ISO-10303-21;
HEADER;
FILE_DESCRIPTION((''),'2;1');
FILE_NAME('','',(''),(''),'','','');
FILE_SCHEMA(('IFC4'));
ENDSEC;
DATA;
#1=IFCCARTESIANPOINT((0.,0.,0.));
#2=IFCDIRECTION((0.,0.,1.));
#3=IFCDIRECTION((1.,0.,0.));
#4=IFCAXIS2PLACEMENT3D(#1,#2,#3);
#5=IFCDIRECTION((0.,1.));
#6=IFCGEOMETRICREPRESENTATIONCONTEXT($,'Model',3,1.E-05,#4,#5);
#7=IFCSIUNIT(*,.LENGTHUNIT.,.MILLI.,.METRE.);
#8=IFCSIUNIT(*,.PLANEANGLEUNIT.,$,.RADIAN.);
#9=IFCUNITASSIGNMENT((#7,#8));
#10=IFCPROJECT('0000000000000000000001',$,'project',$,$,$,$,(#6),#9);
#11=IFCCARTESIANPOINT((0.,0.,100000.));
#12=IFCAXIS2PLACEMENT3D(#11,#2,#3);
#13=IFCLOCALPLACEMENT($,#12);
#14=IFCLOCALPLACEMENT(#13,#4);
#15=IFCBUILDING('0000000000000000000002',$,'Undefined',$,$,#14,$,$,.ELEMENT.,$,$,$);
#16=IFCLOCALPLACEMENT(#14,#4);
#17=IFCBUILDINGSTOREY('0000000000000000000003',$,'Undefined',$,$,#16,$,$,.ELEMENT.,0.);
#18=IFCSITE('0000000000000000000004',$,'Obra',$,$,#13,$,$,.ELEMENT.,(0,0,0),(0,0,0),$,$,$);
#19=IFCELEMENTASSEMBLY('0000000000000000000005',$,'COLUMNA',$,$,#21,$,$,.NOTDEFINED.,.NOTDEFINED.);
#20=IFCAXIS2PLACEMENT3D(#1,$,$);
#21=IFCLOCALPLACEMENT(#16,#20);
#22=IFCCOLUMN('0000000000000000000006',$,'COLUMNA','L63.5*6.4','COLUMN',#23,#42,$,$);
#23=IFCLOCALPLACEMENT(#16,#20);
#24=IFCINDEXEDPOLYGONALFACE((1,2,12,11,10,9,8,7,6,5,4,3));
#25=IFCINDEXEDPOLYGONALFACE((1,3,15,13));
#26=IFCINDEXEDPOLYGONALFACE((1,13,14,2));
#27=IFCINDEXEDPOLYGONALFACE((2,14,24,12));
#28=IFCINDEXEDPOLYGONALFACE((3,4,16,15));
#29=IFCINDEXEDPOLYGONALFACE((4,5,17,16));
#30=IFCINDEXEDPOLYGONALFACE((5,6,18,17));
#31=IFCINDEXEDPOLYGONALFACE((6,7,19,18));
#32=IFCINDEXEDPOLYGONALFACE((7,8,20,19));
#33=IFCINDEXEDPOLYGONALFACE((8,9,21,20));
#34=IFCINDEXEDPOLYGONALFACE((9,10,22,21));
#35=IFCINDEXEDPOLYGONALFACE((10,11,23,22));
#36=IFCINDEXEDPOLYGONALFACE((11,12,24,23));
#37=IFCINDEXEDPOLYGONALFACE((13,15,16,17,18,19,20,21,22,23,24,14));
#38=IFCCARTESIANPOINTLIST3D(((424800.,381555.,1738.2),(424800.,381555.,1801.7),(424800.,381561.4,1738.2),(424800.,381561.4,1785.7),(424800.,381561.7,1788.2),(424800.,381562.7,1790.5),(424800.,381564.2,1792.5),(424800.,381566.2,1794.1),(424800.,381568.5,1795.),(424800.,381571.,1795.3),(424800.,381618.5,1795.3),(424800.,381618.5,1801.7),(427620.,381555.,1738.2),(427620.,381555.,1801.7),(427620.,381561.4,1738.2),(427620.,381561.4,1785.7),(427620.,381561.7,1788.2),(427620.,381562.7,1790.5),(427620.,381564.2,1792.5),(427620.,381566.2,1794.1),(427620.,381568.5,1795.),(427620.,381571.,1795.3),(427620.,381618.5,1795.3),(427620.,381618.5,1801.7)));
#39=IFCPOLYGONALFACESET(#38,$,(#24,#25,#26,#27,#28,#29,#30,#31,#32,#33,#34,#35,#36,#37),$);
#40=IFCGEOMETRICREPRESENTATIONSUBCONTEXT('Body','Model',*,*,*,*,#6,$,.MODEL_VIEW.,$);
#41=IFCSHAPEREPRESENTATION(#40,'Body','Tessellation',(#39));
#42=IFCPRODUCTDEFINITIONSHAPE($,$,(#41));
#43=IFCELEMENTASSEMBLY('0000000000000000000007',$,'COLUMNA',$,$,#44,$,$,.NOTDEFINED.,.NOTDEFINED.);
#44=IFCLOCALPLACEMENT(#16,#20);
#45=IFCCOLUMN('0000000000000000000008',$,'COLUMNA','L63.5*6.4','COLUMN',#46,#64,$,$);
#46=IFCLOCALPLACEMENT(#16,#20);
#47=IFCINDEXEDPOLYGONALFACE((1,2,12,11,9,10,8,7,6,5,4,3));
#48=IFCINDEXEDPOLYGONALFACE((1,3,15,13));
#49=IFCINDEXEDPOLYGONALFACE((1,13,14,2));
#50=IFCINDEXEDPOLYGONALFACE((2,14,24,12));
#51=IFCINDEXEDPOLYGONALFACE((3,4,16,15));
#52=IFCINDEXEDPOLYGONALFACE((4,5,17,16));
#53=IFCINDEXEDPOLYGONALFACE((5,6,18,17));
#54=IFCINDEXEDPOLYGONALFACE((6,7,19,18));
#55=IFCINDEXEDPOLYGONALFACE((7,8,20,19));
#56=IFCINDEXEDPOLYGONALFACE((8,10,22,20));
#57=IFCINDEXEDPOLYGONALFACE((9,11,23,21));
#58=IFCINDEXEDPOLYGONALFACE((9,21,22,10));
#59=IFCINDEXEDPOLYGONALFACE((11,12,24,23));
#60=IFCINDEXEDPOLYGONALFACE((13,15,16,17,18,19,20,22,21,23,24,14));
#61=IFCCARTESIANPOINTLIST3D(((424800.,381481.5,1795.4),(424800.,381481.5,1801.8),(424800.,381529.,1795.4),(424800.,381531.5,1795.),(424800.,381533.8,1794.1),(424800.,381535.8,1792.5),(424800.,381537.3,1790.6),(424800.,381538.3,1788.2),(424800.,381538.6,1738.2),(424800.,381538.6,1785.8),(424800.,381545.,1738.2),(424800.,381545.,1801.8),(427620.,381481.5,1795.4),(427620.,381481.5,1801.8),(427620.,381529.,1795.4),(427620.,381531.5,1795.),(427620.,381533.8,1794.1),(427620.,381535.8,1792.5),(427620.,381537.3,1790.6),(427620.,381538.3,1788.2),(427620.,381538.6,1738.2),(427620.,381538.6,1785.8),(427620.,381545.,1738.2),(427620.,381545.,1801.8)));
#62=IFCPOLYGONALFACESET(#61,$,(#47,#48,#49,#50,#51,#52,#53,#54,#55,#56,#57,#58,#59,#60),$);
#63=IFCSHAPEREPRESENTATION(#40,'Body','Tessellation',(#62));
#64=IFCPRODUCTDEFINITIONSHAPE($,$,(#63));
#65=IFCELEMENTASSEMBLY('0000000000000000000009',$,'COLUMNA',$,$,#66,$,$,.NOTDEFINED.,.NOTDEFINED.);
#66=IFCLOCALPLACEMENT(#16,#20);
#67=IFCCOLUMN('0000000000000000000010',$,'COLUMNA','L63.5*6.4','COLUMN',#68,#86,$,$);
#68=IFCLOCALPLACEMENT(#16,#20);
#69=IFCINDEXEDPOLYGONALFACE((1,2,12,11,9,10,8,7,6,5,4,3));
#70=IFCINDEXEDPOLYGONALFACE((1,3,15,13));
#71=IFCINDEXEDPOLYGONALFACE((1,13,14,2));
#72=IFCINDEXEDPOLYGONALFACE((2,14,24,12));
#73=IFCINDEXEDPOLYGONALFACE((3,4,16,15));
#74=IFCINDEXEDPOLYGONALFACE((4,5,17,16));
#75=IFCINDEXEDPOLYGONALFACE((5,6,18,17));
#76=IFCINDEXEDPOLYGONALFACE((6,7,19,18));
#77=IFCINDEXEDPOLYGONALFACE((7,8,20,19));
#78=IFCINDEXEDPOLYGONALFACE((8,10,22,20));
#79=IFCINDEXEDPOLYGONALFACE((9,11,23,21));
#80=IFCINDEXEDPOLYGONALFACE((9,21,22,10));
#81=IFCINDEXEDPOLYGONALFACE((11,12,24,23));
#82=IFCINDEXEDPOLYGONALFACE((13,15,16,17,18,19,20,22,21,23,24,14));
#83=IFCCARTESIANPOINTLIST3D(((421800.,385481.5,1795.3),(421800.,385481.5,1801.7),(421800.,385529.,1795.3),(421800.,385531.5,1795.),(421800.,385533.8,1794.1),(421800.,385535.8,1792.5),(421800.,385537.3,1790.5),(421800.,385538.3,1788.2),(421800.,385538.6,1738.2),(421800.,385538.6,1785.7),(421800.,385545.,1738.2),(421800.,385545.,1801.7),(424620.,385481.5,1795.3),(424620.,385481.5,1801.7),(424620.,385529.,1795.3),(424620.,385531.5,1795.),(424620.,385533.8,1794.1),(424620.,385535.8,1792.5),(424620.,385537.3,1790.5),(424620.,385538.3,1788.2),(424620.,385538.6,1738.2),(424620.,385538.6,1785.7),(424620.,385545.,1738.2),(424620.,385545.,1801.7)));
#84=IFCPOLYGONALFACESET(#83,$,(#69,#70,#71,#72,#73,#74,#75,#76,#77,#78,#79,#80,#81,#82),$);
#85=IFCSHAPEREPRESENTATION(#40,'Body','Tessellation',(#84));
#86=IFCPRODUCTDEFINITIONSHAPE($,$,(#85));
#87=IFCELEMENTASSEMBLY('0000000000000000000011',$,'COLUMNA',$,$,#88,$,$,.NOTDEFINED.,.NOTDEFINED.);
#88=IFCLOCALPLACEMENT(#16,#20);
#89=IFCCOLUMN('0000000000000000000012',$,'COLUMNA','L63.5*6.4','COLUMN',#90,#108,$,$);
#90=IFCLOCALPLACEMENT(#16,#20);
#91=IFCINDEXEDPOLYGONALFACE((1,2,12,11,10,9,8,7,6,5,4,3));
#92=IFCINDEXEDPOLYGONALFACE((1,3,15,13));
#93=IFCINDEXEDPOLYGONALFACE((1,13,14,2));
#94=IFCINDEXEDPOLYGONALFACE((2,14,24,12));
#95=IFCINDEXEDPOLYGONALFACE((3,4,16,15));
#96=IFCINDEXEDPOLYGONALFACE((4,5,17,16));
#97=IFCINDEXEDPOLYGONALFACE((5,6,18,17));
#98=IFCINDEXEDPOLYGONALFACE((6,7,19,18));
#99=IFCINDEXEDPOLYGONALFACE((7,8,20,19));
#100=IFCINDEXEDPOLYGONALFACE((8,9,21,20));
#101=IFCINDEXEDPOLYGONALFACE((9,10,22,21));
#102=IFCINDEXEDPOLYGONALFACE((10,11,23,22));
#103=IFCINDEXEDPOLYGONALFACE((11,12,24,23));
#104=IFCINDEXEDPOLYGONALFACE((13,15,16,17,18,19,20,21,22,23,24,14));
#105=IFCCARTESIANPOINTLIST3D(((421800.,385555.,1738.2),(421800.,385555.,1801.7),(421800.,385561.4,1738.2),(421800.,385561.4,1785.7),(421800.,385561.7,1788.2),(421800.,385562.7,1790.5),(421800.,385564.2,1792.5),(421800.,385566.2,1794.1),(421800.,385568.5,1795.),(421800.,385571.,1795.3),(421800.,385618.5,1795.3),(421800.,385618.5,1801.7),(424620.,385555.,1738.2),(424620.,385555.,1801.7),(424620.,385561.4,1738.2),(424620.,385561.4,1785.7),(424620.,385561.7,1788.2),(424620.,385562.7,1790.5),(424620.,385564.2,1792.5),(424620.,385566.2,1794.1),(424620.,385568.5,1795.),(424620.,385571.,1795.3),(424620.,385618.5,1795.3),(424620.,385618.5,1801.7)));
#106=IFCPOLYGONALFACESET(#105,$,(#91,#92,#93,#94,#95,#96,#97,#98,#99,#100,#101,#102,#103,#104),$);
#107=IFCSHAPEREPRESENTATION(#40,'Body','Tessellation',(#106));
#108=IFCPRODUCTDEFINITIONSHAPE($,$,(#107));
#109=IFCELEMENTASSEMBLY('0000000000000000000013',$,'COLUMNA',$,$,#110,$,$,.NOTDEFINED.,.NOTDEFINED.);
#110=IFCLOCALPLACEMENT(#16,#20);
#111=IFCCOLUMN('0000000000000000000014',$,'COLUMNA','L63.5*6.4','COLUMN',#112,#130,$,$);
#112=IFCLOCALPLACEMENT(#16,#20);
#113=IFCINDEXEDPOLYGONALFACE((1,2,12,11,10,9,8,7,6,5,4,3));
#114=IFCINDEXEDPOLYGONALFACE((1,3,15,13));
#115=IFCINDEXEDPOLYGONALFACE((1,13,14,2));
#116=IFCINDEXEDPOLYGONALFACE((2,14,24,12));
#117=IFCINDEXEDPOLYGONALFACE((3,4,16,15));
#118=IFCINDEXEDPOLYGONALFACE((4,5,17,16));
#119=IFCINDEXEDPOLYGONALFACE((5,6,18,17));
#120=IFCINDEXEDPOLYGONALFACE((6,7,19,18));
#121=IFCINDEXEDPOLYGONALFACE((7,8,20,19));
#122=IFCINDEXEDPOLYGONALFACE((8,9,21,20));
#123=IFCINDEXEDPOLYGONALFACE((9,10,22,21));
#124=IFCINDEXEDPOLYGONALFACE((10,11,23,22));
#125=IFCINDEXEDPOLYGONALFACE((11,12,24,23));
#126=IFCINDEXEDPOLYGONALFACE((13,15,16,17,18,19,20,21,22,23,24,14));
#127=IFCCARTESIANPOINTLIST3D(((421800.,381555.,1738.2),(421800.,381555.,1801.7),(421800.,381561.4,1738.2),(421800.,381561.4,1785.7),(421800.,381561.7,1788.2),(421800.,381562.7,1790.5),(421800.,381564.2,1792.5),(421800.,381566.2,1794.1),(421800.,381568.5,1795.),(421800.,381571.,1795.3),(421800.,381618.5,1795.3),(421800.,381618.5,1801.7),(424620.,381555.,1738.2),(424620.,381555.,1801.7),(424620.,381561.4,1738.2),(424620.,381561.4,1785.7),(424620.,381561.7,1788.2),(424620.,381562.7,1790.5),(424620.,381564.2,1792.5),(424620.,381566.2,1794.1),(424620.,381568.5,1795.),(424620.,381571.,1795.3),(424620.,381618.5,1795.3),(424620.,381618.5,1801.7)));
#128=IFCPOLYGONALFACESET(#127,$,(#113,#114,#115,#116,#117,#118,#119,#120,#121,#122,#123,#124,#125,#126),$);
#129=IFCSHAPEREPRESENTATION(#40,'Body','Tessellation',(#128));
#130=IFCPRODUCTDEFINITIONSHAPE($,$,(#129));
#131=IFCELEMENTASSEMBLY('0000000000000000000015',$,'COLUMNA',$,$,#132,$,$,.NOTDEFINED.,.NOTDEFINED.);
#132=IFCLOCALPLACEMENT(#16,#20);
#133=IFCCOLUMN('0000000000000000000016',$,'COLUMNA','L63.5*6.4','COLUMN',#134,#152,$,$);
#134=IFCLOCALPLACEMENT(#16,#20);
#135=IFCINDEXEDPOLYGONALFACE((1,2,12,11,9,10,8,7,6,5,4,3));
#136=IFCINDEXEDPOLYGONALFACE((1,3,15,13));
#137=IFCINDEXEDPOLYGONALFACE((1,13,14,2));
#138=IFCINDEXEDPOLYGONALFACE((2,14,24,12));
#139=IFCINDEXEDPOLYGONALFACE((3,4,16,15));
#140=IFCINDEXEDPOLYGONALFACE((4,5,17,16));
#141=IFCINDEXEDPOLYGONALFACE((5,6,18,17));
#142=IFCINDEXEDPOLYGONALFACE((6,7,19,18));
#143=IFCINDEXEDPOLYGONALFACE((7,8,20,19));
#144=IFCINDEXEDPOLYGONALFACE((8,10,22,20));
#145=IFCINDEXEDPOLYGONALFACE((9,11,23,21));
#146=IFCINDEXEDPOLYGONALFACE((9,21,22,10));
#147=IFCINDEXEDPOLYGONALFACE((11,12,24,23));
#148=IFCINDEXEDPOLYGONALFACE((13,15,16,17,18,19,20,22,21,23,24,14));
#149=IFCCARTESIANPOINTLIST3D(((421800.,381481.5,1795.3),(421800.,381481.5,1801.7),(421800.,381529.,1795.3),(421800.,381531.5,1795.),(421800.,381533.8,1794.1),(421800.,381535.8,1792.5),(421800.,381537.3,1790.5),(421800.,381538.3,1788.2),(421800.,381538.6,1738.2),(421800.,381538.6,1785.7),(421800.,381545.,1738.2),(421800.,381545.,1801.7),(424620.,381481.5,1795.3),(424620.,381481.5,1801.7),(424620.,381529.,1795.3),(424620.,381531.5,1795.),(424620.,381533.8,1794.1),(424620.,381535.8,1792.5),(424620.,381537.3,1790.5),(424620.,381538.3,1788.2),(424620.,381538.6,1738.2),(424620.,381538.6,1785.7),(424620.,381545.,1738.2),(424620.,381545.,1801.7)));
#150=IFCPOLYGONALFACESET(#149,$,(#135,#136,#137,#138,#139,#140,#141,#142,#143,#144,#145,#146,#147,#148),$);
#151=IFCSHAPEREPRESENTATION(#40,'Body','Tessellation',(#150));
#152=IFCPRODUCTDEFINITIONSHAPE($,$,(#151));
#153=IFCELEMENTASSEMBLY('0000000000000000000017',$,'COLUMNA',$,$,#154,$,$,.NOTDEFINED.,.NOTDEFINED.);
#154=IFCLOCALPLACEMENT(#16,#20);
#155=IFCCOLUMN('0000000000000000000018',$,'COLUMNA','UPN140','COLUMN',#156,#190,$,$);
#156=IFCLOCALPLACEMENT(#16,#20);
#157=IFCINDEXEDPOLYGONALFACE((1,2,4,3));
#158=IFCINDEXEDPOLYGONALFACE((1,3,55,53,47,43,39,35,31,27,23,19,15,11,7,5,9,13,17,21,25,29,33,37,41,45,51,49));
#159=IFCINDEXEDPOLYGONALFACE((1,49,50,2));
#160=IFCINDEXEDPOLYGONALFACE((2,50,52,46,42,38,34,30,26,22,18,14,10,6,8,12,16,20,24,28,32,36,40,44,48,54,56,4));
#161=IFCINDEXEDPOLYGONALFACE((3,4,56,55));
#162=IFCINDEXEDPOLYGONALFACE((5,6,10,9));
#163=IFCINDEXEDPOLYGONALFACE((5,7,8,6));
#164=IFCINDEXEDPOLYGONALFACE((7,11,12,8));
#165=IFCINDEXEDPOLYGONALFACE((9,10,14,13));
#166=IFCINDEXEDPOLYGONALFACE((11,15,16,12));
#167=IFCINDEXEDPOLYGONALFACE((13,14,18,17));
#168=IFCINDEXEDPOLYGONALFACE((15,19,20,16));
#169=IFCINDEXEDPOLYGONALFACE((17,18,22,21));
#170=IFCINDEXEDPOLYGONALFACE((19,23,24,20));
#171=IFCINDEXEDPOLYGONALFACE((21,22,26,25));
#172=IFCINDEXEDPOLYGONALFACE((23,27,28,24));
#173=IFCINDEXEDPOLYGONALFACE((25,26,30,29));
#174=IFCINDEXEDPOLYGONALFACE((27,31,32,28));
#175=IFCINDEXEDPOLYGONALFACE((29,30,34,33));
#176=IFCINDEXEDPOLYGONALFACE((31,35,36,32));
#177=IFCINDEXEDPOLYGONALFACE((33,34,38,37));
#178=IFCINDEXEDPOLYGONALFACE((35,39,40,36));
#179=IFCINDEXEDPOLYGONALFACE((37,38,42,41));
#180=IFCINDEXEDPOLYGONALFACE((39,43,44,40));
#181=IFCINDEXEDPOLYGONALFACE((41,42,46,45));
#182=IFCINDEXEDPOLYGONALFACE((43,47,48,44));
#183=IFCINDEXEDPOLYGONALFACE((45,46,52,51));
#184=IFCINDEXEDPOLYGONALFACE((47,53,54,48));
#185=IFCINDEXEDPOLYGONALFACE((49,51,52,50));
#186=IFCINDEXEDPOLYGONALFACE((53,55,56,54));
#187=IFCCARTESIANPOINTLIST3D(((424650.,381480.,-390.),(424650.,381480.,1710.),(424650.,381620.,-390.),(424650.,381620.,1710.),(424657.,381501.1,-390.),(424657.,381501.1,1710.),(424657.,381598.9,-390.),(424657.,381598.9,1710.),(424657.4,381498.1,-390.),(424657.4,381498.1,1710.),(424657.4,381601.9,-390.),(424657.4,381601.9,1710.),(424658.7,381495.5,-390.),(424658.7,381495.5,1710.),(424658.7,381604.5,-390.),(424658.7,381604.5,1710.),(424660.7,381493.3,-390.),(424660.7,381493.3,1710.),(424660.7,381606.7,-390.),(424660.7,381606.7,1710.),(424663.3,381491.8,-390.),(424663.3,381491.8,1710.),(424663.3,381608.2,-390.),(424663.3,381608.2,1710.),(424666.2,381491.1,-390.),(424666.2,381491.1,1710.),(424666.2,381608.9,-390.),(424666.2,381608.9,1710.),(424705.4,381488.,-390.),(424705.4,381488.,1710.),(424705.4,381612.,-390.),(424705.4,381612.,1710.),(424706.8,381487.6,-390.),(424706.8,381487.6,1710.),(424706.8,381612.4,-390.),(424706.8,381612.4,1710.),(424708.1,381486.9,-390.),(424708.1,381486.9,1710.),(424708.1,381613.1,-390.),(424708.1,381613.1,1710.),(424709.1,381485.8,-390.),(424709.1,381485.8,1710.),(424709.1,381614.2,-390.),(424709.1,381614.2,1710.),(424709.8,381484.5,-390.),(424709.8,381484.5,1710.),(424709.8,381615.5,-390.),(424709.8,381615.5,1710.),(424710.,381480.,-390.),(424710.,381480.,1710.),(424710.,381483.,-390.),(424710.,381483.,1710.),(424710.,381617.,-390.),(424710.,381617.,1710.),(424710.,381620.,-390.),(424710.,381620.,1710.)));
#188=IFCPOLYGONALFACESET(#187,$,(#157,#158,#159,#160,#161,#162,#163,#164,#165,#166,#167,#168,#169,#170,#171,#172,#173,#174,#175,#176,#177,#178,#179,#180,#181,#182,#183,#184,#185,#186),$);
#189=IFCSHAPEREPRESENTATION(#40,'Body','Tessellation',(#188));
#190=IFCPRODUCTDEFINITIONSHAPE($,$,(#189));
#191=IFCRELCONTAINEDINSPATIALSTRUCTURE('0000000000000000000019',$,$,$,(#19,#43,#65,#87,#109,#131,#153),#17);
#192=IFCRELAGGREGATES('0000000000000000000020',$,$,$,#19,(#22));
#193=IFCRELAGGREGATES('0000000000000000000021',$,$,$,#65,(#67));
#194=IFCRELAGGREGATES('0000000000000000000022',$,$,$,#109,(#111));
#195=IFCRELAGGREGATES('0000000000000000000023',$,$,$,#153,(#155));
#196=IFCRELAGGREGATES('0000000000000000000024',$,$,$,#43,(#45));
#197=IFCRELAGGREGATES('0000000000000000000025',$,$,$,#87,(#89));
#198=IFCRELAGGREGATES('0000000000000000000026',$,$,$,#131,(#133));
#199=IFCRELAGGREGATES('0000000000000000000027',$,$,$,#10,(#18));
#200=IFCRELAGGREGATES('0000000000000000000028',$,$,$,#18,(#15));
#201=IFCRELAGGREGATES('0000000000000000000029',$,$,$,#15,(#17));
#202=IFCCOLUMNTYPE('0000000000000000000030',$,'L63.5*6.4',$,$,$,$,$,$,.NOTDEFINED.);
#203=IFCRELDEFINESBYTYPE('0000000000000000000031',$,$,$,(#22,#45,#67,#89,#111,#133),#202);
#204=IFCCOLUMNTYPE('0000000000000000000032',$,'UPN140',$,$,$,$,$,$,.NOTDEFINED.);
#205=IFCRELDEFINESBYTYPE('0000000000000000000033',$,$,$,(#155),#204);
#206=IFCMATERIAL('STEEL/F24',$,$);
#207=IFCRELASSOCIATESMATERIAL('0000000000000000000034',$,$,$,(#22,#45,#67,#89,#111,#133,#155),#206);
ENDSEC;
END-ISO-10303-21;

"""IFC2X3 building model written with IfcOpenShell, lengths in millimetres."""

from ifc_helpers import new_model, si_unit, direction, frame, origin_with_axes, origin_2d_with_axis, place, context, subcontext, project, spatial, l_section, u_section, extrude, material, type_object, element, aggregate, save


model = new_model("IFC2X3")

# Units and contexts
model_context = context("Model", 3, precision=1e-05, world=origin_with_axes(), true_north=direction((0.0, 1.0)))
body_context = subcontext(model_context, "Body", "Model", "MODEL_VIEW")
ifc_project = project(units=[si_unit("LENGTHUNIT", "METRE", prefix="MILLI"), si_unit("PLANEANGLEUNIT", "RADIAN")], contexts=[model_context])

# Site, building, storey
site_placement = place(None, frame((0.0, 0.0, 100000.0), z_axis=(0.0, 0.0, 1.0), x_axis=(1.0, 0.0, 0.0)))
site = spatial("IfcSite", under=ifc_project, at=site_placement, Name="Obra", CompositionType="ELEMENT", RefLatitude=(0, 0, 0), RefLongitude=(0, 0, 0))
building_placement = place(site_placement, origin_with_axes())
building = spatial("IfcBuilding", under=site, at=building_placement, Name="Undefined", CompositionType="ELEMENT")
storey_placement = place(building_placement, origin_with_axes())
storey = spatial("IfcBuildingStorey", under=building, at=storey_placement, Name="Undefined", CompositionType="ELEMENT", Elevation=0.0)

# Element assemblies, columns
assembly_1_placement = place(storey_placement, origin_with_axes())
assembly_1 = element("IfcElementAssembly", 1, at=assembly_1_placement, inside=storey, Name="COLUMNA", AssemblyPlace="NOTDEFINED", PredefinedType="NOTDEFINED")
ifc_material_1 = material(Name="STEEL/F24")
column_type_1 = type_object("IfcColumnType", Name="L63.5*6.4", PredefinedType="NOTDEFINED")
column_1_placement = place(assembly_1_placement, frame((424800.0, 381586.7, 1770.0), z_axis=(1.0, 0.0, 0.0), x_axis=(0.0, 0.0, -1.0)))
column_1 = element("IfcColumn", 2, at=column_1_placement, type_object=column_type_1, material=ifc_material_1, Name="COLUMNA", Description="L63.5*6.4", ObjectType="COLUMN", context=body_context, shape_type="SweptSolid", body=[
    extrude(l_section(Depth=63.5, Width=63.5, Thickness=6.4, FilletRadius=9.6, at=origin_2d_with_axis()), frame((0.0, 0.0, 2820.0), z_axis=(0.0, 0.0, -1.0), x_axis=(0.0, 1.0, 0.0)), (0.0, 0.0, 1.0), 2820.0),
])
aggregate(assembly_1, [column_1])
assembly_2_placement = place(storey_placement, origin_with_axes())
assembly_2 = element("IfcElementAssembly", 3, at=assembly_2_placement, inside=storey, Name="COLUMNA", AssemblyPlace="NOTDEFINED", PredefinedType="NOTDEFINED")
column_2_placement = place(assembly_2_placement, frame((424800.0, 381513.2, 1770.0), z_axis=(1.0, 0.0, 0.0), x_axis=(0.0, -1.0, 0.0)))
column_2 = element("IfcColumn", 4, at=column_2_placement, type_object=column_type_1, material=ifc_material_1, Name="COLUMNA", Description="L63.5*6.4", ObjectType="COLUMN", context=body_context, shape_type="SweptSolid", body=[
    extrude(l_section(Depth=63.5, Width=63.5, Thickness=6.4, FilletRadius=9.6, at=origin_2d_with_axis()), frame((0.0, 0.0, 2820.0), z_axis=(0.0, 0.0, -1.0), x_axis=(0.0, 1.0, 0.0)), (0.0, 0.0, 1.0), 2820.0),
])
assembly_3_placement = place(storey_placement, origin_with_axes())
assembly_3 = element("IfcElementAssembly", 5, at=assembly_3_placement, inside=storey, Name="COLUMNA", AssemblyPlace="NOTDEFINED", PredefinedType="NOTDEFINED")
column_3_placement = place(assembly_3_placement, frame((424620.0, 385513.3, 1770.0), z_axis=(-1.0, 0.0, 0.0), x_axis=(0.0, 0.0, -1.0)))
column_3 = element("IfcColumn", 6, at=column_3_placement, type_object=column_type_1, material=ifc_material_1, Name="COLUMNA", Description="L63.5*6.4", ObjectType="COLUMN", context=body_context, shape_type="SweptSolid", body=[
    extrude(l_section(Depth=63.5, Width=63.5, Thickness=6.4, FilletRadius=9.6, at=origin_2d_with_axis()), frame((0.0, 0.0, 2820.0), z_axis=(0.0, 0.0, -1.0), x_axis=(0.0, 1.0, 0.0)), (0.0, 0.0, 1.0), 2820.0),
])
aggregate(assembly_3, [column_3])
assembly_4_placement = place(storey_placement, origin_with_axes())
assembly_4 = element("IfcElementAssembly", 7, at=assembly_4_placement, inside=storey, Name="COLUMNA", AssemblyPlace="NOTDEFINED", PredefinedType="NOTDEFINED")
column_4_placement = place(assembly_4_placement, frame((424620.0, 385586.8, 1770.0), z_axis=(-1.0, 0.0, 0.0), x_axis=(0.0, 1.0, 0.0)))
column_4 = element("IfcColumn", 8, at=column_4_placement, type_object=column_type_1, material=ifc_material_1, Name="COLUMNA", Description="L63.5*6.4", ObjectType="COLUMN", context=body_context, shape_type="SweptSolid", body=[
    extrude(l_section(Depth=63.5, Width=63.5, Thickness=6.4, FilletRadius=9.6, at=origin_2d_with_axis()), frame((0.0, 0.0, 2820.0), z_axis=(0.0, 0.0, -1.0), x_axis=(0.0, 1.0, 0.0)), (0.0, 0.0, 1.0), 2820.0),
])
assembly_5_placement = place(storey_placement, origin_with_axes())
assembly_5 = element("IfcElementAssembly", 9, at=assembly_5_placement, inside=storey, Name="COLUMNA", AssemblyPlace="NOTDEFINED", PredefinedType="NOTDEFINED")
column_5_placement = place(assembly_5_placement, frame((421800.0, 381586.7, 1770.0), z_axis=(1.0, 0.0, 0.0), x_axis=(0.0, 0.0, -1.0)))
column_5 = element("IfcColumn", 10, at=column_5_placement, type_object=column_type_1, material=ifc_material_1, Name="COLUMNA", Description="L63.5*6.4", ObjectType="COLUMN", context=body_context, shape_type="SweptSolid", body=[
    extrude(l_section(Depth=63.5, Width=63.5, Thickness=6.4, FilletRadius=9.6, at=origin_2d_with_axis()), frame((0.0, 0.0, 2820.0), z_axis=(0.0, 0.0, -1.0), x_axis=(0.0, 1.0, 0.0)), (0.0, 0.0, 1.0), 2820.0),
])
aggregate(assembly_5, [column_5])
assembly_6_placement = place(storey_placement, origin_with_axes())
assembly_6 = element("IfcElementAssembly", 11, at=assembly_6_placement, inside=storey, Name="COLUMNA", AssemblyPlace="NOTDEFINED", PredefinedType="NOTDEFINED")
column_6_placement = place(assembly_6_placement, frame((421800.0, 381513.2, 1770.0), z_axis=(1.0, 0.0, 0.0), x_axis=(0.0, -1.0, 0.0)))
column_6 = element("IfcColumn", 12, at=column_6_placement, type_object=column_type_1, material=ifc_material_1, Name="COLUMNA", Description="L63.5*6.4", ObjectType="COLUMN", context=body_context, shape_type="SweptSolid", body=[
    extrude(l_section(Depth=63.5, Width=63.5, Thickness=6.4, FilletRadius=9.6, at=origin_2d_with_axis()), frame((0.0, 0.0, 2820.0), z_axis=(0.0, 0.0, -1.0), x_axis=(0.0, 1.0, 0.0)), (0.0, 0.0, 1.0), 2820.0),
])
assembly_7_placement = place(storey_placement, origin_with_axes())
assembly_7 = element("IfcElementAssembly", 13, at=assembly_7_placement, inside=storey, Name="COLUMNA", AssemblyPlace="NOTDEFINED", PredefinedType="NOTDEFINED")
column_type_2 = type_object("IfcColumnType", Name="UPN140", PredefinedType="NOTDEFINED")
column_7_placement = place(assembly_7_placement, frame((424680.0, 381550.0, 1710.0), z_axis=(0.0, 0.0, -1.0), x_axis=(0.0, 1.0, 0.0)))
column_7 = element("IfcColumn", 14, at=column_7_placement, type_object=column_type_2, material=ifc_material_1, Name="COLUMNA", Description="UPN140", ObjectType="COLUMN", context=body_context, shape_type="SweptSolid", body=[
    extrude(u_section(Depth=140.0, FlangeWidth=60.0, WebThickness=7.0, FlangeThickness=10.0, FilletRadius=10.0, EdgeRadius=5.0, FlangeSlope=0.07983, at=origin_2d_with_axis()), frame((0.0, 0.0, 2100.0), z_axis=(0.0, 0.0, -1.0), x_axis=(0.0, 1.0, 0.0)), (0.0, 0.0, 1.0), 2100.0),
])
aggregate(assembly_7, [column_7])

aggregate(assembly_2, [column_2])

aggregate(assembly_4, [column_4])
aggregate(assembly_6, [column_6])

save(model, "model.ifc")
